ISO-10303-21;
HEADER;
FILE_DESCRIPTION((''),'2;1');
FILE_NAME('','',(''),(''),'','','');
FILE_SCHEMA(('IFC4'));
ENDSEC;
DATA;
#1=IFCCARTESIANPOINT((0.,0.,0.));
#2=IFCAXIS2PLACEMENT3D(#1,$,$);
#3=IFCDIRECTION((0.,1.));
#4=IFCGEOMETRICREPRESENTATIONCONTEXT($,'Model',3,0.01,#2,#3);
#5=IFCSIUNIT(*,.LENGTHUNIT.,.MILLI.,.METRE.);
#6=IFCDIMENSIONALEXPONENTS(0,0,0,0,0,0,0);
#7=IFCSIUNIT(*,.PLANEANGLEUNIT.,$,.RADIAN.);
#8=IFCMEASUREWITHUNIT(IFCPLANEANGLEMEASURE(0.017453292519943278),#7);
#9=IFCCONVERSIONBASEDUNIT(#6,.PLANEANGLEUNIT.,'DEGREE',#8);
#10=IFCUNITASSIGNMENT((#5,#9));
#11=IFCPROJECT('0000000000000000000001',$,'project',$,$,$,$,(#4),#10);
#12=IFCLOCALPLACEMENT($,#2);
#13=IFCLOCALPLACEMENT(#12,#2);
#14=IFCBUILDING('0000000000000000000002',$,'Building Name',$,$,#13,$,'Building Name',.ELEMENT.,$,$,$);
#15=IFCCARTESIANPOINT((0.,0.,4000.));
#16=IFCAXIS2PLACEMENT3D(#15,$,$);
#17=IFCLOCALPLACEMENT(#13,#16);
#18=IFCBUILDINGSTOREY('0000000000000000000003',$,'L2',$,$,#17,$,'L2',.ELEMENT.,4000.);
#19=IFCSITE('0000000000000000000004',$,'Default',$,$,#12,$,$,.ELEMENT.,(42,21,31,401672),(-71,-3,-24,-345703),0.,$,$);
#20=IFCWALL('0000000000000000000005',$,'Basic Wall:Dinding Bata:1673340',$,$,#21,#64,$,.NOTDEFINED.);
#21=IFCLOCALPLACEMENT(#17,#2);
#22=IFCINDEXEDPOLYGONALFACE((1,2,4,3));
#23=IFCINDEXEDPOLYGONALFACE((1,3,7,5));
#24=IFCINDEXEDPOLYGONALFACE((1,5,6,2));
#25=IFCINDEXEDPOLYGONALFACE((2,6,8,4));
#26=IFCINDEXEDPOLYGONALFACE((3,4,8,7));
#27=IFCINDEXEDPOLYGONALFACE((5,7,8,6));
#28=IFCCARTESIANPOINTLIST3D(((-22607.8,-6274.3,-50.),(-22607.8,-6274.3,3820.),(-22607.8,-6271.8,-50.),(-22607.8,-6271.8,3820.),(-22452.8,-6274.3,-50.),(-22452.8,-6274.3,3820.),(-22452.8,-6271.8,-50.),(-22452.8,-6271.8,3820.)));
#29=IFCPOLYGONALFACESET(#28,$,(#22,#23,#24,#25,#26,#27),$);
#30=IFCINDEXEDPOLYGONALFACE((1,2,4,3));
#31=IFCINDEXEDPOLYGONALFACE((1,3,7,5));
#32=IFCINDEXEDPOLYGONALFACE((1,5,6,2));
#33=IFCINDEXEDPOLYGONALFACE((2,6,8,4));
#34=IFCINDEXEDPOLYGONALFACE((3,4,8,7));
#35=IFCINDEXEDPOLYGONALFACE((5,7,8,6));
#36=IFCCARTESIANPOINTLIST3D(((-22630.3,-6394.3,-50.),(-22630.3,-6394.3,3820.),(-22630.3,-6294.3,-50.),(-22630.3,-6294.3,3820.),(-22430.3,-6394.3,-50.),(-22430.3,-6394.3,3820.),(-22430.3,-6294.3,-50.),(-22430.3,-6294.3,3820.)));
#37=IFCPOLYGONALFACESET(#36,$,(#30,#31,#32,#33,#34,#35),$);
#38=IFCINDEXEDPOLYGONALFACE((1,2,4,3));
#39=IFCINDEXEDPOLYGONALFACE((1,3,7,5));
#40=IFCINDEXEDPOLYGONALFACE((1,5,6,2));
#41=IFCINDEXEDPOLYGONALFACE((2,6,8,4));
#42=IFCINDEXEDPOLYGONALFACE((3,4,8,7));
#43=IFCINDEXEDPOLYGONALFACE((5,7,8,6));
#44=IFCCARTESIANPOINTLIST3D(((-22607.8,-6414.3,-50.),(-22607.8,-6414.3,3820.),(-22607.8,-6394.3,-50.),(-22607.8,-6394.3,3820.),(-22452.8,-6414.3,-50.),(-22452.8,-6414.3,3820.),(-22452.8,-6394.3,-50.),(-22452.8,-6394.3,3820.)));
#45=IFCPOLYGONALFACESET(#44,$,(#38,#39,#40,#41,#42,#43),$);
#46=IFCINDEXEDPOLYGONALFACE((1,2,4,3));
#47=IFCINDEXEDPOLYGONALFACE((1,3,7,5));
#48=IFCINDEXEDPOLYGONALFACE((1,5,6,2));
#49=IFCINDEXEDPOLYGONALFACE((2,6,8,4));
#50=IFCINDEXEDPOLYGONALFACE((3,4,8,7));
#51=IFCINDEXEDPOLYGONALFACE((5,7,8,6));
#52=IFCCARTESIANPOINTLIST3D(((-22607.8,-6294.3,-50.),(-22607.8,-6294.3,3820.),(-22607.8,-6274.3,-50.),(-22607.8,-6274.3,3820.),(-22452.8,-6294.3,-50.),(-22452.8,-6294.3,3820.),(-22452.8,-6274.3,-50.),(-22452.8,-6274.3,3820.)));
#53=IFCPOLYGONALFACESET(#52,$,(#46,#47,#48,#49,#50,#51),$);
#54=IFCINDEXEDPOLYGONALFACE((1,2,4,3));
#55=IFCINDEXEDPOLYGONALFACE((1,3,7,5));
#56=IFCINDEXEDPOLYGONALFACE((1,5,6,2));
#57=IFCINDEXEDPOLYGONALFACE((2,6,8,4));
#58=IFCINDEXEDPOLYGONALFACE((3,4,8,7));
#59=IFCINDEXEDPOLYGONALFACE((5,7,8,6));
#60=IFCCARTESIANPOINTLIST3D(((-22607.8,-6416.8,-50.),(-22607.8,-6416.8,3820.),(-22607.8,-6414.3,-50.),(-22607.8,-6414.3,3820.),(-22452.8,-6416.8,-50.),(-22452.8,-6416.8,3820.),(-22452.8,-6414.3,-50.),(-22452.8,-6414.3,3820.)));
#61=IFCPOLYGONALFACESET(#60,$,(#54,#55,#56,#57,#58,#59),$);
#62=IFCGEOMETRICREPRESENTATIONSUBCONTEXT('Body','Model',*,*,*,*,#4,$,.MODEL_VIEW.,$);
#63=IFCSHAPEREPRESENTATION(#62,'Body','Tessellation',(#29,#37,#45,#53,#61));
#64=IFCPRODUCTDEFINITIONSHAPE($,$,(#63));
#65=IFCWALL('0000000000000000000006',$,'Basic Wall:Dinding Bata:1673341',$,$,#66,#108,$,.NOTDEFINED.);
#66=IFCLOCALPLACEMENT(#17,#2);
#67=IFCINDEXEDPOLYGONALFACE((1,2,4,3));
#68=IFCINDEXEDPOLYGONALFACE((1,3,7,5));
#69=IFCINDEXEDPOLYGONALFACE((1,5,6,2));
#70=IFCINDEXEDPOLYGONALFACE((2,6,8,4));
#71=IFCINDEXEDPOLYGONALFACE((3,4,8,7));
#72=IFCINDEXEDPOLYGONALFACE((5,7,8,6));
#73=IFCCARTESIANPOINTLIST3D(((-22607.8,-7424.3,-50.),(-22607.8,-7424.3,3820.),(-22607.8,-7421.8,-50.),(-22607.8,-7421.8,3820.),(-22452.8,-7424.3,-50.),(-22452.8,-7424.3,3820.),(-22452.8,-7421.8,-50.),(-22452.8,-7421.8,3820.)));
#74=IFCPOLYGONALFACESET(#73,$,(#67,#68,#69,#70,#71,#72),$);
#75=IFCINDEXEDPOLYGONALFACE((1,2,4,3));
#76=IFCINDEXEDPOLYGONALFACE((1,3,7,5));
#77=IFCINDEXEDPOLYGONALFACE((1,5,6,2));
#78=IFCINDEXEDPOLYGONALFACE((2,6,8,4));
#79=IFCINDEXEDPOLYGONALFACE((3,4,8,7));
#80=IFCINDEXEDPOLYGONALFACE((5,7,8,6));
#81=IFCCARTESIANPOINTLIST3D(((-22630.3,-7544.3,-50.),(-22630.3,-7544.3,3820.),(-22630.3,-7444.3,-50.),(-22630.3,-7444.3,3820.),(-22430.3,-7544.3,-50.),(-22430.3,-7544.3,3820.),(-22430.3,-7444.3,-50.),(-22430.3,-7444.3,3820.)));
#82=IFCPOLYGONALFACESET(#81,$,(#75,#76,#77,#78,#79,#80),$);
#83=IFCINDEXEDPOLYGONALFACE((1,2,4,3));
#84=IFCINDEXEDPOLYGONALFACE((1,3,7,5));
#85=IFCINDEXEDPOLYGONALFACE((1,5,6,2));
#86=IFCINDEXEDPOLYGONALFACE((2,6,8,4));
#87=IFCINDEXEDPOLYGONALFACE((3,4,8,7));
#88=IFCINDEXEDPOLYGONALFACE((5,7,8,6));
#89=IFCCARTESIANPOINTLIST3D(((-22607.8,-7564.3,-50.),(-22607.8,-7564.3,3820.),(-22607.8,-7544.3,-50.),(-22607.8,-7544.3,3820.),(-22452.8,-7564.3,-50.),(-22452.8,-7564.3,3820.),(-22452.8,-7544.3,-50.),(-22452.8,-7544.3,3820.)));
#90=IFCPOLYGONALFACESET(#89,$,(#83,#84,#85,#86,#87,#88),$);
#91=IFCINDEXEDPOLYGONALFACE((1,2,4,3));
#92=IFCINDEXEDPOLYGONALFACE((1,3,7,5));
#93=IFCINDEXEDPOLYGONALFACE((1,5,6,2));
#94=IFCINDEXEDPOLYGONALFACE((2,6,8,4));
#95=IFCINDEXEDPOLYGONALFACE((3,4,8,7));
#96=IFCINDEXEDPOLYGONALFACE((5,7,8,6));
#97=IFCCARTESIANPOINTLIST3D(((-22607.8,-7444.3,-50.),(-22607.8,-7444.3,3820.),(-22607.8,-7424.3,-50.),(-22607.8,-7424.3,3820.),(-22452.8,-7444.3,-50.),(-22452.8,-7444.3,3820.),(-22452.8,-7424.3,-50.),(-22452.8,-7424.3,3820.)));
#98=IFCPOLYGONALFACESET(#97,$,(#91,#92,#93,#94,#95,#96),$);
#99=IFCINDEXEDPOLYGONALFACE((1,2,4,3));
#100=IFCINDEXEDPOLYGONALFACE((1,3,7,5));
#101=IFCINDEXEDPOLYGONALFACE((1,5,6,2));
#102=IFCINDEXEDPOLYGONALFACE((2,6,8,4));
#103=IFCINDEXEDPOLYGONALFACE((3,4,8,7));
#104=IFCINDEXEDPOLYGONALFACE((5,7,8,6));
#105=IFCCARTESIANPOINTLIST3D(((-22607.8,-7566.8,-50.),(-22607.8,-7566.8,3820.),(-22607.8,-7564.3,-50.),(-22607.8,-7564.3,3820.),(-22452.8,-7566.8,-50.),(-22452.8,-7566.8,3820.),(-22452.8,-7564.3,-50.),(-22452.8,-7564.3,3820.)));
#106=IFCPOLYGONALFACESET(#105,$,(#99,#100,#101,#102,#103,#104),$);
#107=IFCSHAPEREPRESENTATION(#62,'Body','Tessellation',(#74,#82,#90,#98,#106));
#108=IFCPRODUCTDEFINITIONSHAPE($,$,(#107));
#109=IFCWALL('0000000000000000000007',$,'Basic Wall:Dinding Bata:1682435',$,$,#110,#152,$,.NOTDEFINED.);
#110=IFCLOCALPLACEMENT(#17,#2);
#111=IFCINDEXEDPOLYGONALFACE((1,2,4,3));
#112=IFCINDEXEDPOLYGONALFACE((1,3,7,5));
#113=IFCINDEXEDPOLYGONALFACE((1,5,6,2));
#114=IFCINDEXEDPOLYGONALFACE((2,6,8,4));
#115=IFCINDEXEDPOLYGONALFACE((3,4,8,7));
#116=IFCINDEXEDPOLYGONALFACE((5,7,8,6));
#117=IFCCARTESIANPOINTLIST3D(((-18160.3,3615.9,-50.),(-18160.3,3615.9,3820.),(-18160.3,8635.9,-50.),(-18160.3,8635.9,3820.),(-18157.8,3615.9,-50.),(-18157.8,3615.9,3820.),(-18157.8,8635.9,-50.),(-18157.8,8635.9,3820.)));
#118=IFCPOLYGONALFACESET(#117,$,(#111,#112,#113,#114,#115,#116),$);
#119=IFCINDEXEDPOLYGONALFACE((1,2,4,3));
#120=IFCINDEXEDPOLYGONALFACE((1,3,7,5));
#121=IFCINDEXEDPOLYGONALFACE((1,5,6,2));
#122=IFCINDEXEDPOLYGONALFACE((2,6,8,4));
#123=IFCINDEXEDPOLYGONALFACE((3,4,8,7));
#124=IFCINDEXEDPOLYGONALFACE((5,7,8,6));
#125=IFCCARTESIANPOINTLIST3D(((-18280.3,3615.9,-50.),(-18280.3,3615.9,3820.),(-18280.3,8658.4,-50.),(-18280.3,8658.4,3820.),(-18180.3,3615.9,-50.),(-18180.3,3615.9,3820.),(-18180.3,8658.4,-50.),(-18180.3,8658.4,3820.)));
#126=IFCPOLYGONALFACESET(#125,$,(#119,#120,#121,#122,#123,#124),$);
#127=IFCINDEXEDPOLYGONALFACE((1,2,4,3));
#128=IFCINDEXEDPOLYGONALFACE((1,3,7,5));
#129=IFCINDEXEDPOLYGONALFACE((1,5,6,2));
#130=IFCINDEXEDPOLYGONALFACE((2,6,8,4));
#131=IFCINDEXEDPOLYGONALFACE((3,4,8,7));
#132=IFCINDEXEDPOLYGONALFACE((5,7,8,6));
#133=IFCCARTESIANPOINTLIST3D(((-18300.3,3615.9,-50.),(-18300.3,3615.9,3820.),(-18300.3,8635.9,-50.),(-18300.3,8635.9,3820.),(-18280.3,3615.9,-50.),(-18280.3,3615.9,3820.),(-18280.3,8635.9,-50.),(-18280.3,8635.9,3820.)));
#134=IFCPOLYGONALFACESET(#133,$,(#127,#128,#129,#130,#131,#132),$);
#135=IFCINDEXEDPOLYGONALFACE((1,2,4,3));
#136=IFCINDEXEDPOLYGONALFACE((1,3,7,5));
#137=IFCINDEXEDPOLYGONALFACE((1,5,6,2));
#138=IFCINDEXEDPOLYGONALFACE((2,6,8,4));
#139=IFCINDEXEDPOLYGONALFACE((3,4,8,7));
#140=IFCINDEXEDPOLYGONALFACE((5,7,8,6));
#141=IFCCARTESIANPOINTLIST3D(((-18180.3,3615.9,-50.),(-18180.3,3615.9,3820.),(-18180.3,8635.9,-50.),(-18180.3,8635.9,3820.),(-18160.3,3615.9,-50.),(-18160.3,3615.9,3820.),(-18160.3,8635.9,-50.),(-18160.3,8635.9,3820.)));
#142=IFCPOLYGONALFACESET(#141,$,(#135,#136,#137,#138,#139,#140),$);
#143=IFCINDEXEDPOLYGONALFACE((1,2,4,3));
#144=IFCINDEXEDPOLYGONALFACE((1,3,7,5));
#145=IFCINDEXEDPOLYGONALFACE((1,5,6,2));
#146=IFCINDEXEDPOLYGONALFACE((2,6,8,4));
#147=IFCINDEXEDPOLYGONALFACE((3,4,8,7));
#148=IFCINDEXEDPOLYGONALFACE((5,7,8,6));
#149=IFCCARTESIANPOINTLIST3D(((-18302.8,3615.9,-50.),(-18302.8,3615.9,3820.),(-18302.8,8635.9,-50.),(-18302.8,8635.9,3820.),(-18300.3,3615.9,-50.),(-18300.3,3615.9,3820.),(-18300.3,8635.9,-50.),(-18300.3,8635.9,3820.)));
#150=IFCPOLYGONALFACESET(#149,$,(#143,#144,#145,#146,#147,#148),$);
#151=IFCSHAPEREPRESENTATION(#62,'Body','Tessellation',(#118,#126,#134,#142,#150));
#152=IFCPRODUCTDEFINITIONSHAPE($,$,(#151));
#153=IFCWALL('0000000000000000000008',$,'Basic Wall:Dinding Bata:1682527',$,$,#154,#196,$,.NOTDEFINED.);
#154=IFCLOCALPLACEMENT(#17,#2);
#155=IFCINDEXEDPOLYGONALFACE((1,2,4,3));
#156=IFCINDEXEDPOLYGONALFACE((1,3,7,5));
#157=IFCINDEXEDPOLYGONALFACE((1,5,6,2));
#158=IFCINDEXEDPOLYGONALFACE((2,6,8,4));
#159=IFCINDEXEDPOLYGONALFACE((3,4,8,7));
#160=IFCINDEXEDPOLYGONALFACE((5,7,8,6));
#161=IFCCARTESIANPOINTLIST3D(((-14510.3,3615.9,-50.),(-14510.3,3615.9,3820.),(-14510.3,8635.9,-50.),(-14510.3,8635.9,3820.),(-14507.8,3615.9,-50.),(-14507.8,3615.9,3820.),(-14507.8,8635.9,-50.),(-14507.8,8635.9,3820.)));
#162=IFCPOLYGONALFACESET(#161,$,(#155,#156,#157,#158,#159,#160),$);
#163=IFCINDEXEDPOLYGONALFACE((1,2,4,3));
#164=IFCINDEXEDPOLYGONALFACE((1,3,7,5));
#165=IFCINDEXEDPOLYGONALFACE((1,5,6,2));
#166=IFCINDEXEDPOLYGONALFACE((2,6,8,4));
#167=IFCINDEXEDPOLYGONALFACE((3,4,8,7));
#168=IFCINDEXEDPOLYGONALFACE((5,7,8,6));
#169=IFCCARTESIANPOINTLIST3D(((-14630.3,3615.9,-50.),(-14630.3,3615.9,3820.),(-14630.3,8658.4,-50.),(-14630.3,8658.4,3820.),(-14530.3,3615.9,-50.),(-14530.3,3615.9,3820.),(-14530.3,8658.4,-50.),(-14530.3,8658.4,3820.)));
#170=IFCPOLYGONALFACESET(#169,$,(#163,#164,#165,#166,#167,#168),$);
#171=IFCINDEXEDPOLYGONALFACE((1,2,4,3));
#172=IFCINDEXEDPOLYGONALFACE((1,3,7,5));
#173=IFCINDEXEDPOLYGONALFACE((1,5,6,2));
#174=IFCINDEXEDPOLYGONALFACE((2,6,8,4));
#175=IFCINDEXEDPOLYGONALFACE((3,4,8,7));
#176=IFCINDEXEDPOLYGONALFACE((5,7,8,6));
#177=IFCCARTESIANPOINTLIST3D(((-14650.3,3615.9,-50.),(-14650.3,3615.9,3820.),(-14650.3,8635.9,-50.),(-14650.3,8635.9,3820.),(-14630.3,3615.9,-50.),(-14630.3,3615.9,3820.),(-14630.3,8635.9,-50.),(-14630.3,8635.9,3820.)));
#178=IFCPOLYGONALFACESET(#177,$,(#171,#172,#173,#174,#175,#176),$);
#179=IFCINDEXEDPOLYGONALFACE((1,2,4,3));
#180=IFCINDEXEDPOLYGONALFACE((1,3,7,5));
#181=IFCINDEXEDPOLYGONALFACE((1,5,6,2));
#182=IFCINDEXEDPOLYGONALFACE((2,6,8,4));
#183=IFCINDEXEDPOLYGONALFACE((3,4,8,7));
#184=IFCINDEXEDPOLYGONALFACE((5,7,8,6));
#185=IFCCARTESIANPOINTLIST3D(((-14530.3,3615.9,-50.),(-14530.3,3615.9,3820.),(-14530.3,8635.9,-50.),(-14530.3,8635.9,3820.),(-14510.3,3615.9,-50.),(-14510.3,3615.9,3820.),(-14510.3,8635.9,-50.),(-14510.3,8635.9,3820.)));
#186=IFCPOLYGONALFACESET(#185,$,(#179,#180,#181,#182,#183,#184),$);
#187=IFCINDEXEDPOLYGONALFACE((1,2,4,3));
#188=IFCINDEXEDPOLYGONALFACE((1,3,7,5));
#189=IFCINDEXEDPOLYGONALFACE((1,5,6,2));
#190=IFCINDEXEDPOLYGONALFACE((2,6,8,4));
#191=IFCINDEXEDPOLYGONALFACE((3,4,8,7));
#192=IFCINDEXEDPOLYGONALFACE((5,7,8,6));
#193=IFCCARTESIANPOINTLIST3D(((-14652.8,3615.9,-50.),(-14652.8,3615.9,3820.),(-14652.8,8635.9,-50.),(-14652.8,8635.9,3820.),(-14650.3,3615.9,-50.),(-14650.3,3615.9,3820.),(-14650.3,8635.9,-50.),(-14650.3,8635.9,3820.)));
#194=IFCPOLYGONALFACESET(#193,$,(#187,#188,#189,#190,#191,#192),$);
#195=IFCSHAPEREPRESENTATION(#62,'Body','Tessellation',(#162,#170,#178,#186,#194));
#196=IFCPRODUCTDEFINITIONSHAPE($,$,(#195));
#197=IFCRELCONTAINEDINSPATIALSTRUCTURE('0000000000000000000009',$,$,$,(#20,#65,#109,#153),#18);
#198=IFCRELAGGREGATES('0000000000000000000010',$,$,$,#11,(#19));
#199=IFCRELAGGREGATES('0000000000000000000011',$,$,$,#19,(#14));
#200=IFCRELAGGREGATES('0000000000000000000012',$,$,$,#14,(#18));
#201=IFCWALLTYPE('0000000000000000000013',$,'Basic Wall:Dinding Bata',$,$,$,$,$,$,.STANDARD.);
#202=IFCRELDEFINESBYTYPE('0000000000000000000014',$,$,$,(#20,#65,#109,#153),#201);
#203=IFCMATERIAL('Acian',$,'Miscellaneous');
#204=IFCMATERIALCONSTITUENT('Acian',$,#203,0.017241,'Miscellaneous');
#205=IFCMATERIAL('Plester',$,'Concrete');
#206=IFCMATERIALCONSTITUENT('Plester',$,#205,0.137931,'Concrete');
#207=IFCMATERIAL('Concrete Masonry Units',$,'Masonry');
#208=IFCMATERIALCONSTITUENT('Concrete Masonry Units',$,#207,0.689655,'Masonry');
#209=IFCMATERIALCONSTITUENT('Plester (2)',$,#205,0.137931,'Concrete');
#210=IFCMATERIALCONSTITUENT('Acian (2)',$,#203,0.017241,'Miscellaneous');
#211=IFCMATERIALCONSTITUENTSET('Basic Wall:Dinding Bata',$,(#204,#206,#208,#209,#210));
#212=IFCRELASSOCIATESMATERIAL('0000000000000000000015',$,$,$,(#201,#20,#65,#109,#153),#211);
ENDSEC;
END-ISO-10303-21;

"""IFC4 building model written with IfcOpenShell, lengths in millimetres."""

from ifc_helpers import new_model, entity, si_unit, converted_unit, direction, frame, origin, place, context, subcontext, project, spatial, indexed_curve, outline, extrude, material, constituent, constituent_set, type_object, element, save


model = new_model("IFC4")

# Units and contexts
model_context = context("Model", 3, precision=0.01, world=origin(), true_north=direction((0.0, 1.0)))
body_context = subcontext(model_context, "Body", "Model", "MODEL_VIEW")
ifc_project = project(units=[si_unit("LENGTHUNIT", "METRE", prefix="MILLI"), converted_unit("PLANEANGLEUNIT", "DEGREE", entity("IfcPlaneAngleMeasure", 0.017453292519943278), si_unit("PLANEANGLEUNIT", "RADIAN"), dimensions=[0, 0, 0, 0, 0, 0, 0])], contexts=[model_context])

# Site, building, storey
site_placement = place(None, origin())
site = spatial("IfcSite", under=ifc_project, at=site_placement, Name="Default", CompositionType="ELEMENT", RefLatitude=(42, 21, 31, 401672), RefLongitude=(-71, -3, -24, -345703), RefElevation=0.0)
building_placement = place(site_placement, origin())
building = spatial("IfcBuilding", under=site, at=building_placement, Name="Building Name", LongName="Building Name", CompositionType="ELEMENT")
storey_placement = place(building_placement, frame((0.0, 0.0, 4000.0)))
storey = spatial("IfcBuildingStorey", under=building, at=storey_placement, Name="L2", LongName="L2", CompositionType="ELEMENT", Elevation=4000.0)

# Walls
ifc_material_1 = material(Name="Acian", Category="Miscellaneous")
ifc_constituent_1 = constituent(ifc_material_1, Name="Acian", Category="Miscellaneous", fraction=0.017241)
ifc_material_2 = material(Name="Plester", Category="Concrete")
ifc_constituent_2 = constituent(ifc_material_2, Name="Plester", Category="Concrete", fraction=0.137931)
ifc_material_3 = material(Name="Concrete Masonry Units", Category="Masonry")
ifc_constituent_3 = constituent(ifc_material_3, Name="Concrete Masonry Units", Category="Masonry", fraction=0.689655)
ifc_constituent_4 = constituent(ifc_material_2, Name="Plester (2)", Category="Concrete", fraction=0.137931)
ifc_constituent_5 = constituent(ifc_material_1, Name="Acian (2)", Category="Miscellaneous", fraction=0.017241)
ifc_constituent_set = constituent_set(constituents=[ifc_constituent_1, ifc_constituent_2, ifc_constituent_3, ifc_constituent_4, ifc_constituent_5], Name="Basic Wall:Dinding Bata")
wall_type = type_object("IfcWallType", Name="Basic Wall:Dinding Bata", PredefinedType="STANDARD", material=ifc_constituent_set)
wall_1_placement = place(storey_placement, frame((-22607.8, -6344.3, -50.0)))
element("IfcWall", 1, at=wall_1_placement, inside=storey, type_object=wall_type, material=ifc_constituent_set, Name="Basic Wall:Dinding Bata:1673340", PredefinedType="NOTDEFINED", context=body_context, shape_type="SweptSolid", body=[
    extrude(outline(indexed_curve([(-1.2, -77.5), (1.2, -77.5), (1.2, 77.5), (-1.2, 77.5), (-1.2, -77.5)], self_intersect=False)), frame((77.5, 71.3, 0.0), z_axis=(0.0, 0.0, 1.0), x_axis=(0.0, -1.0, 0.0)), (0.0, 0.0, 1.0), 3870.0),
    extrude(outline(indexed_curve([(-100.0, -50.0), (100.0, -50.0), (100.0, 50.0), (-100.0, 50.0), (-100.0, -50.0)], self_intersect=False)), frame((77.5, 0.0, 0.0)), (0.0, 0.0, 1.0), 3870.0),
    extrude(outline(indexed_curve([(-77.5, -10.0), (77.5, -10.0), (77.5, 10.0), (-77.5, 10.0), (-77.5, -10.0)], self_intersect=False)), frame((77.5, -60.0, 0.0)), (0.0, 0.0, 1.0), 3870.0),
    extrude(outline(indexed_curve([(-77.5, -10.0), (77.5, -10.0), (77.5, 10.0), (-77.5, 10.0), (-77.5, -10.0)], self_intersect=False)), frame((77.5, 60.0, 0.0)), (0.0, 0.0, 1.0), 3870.0),
    extrude(outline(indexed_curve([(-1.2, -77.5), (1.2, -77.5), (1.2, 77.5), (-1.2, 77.5), (-1.2, -77.5)], self_intersect=False)), frame((77.5, -71.3, 0.0), z_axis=(0.0, 0.0, 1.0), x_axis=(0.0, 1.0, 0.0)), (0.0, 0.0, 1.0), 3870.0),
])
wall_2_placement = place(storey_placement, frame((-22607.8, -7494.3, -50.0)))
element("IfcWall", 2, at=wall_2_placement, inside=storey, type_object=wall_type, material=ifc_constituent_set, Name="Basic Wall:Dinding Bata:1673341", PredefinedType="NOTDEFINED", context=body_context, shape_type="SweptSolid", body=[
    extrude(outline(indexed_curve([(-1.3, -77.5), (1.2, -77.5), (1.2, 77.5), (-1.2, 77.5), (-1.3, -77.5)], self_intersect=False)), frame((77.5, 71.2, 0.0), z_axis=(0.0, 0.0, 1.0), x_axis=(0.0, -1.0, 0.0)), (0.0, 0.0, 1.0), 3870.0),
    extrude(outline(indexed_curve([(-100.0, -50.0), (100.0, -50.0), (100.0, 50.0), (-100.0, 50.0), (-100.0, -50.0)], self_intersect=False)), frame((77.5, 0.0, 0.0)), (0.0, 0.0, 1.0), 3870.0),
    extrude(outline(indexed_curve([(-77.5, -10.0), (77.5, -10.0), (77.5, 10.0), (-77.5, 10.0), (-77.5, -10.0)], self_intersect=False)), frame((77.5, -60.0, 0.0)), (0.0, 0.0, 1.0), 3870.0),
    extrude(outline(indexed_curve([(-77.5, -10.0), (77.5, -10.0), (77.5, 10.0), (-77.5, 10.0), (-77.5, -10.0)], self_intersect=False)), frame((77.5, 60.0, 0.0)), (0.0, 0.0, 1.0), 3870.0),
    extrude(outline(indexed_curve([(-1.2, -77.5), (1.2, -77.5), (1.3, 77.5), (-1.2, 77.5), (-1.2, -77.5)], self_intersect=False)), frame((77.5, -71.3, 0.0), z_axis=(0.0, 0.0, 1.0), x_axis=(0.0, 1.0, 0.0)), (0.0, 0.0, 1.0), 3870.0),
])
wall_3_placement = place(storey_placement, frame((-18230.3, 8635.9, -50.0), z_axis=(0.0, 0.0, 1.0), x_axis=(0.0, -1.0, 0.0)))
element("IfcWall", 3, at=wall_3_placement, inside=storey, type_object=wall_type, material=ifc_constituent_set, Name="Basic Wall:Dinding Bata:1682435", PredefinedType="NOTDEFINED", context=body_context, shape_type="SweptSolid", body=[
    extrude(outline(indexed_curve([(-1.3, -2510.0), (1.2, -2510.0), (1.3, 2510.0), (-1.2, 2510.0), (-1.3, -2510.0)], self_intersect=False)), frame((2510.0, 71.3, 0.0), z_axis=(0.0, 0.0, 1.0), x_axis=(0.0, -1.0, 0.0)), (0.0, 0.0, 1.0), 3870.0),
    extrude(outline(indexed_curve([(-2521.3, -50.0), (2521.2, -50.0), (2521.2, 50.0), (-2521.2, 50.0), (-2521.3, -50.0)], self_intersect=False)), frame((2498.8, 0.0, 0.0)), (0.0, 0.0, 1.0), 3870.0),
    extrude(outline(indexed_curve([(-2510.0, -10.0), (2510.0, -10.0), (2510.0, 10.0), (-2510.0, 10.0), (-2510.0, -10.0)], self_intersect=False)), frame((2510.0, -60.0, 0.0)), (0.0, 0.0, 1.0), 3870.0),
    extrude(outline(indexed_curve([(-2510.0, -10.0), (2510.0, -10.0), (2510.0, 10.0), (-2510.0, 10.0), (-2510.0, -10.0)], self_intersect=False)), frame((2510.0, 60.0, 0.0)), (0.0, 0.0, 1.0), 3870.0),
    extrude(outline(indexed_curve([(-1.3, -2510.0), (1.2, -2510.0), (1.3, 2510.0), (-1.2, 2510.0), (-1.3, -2510.0)], self_intersect=False)), frame((2510.0, -71.2, 0.0), z_axis=(0.0, 0.0, 1.0), x_axis=(0.0, 1.0, 0.0)), (0.0, 0.0, 1.0), 3870.0),
])
wall_4_placement = place(storey_placement, frame((-14580.3, 8635.9, -50.0), z_axis=(0.0, 0.0, 1.0), x_axis=(0.0, -1.0, 0.0)))
element("IfcWall", 4, at=wall_4_placement, inside=storey, type_object=wall_type, material=ifc_constituent_set, Name="Basic Wall:Dinding Bata:1682527", PredefinedType="NOTDEFINED", context=body_context, shape_type="SweptSolid", body=[
    extrude(outline(indexed_curve([(-1.3, -2510.0), (1.2, -2510.0), (1.3, 2510.0), (-1.2, 2510.0), (-1.3, -2510.0)], self_intersect=False)), frame((2510.0, 71.3, 0.0), z_axis=(0.0, 0.0, 1.0), x_axis=(0.0, -1.0, 0.0)), (0.0, 0.0, 1.0), 3870.0),
    extrude(outline(indexed_curve([(-2521.2, -50.0), (2521.2, -50.0), (2521.2, 50.0), (-2521.2, 50.0), (-2521.2, -50.0)], self_intersect=False)), frame((2498.7, 0.0, 0.0)), (0.0, 0.0, 1.0), 3870.0),
    extrude(outline(indexed_curve([(-2510.0, -10.0), (2510.0, -10.0), (2510.0, 10.0), (-2510.0, 10.0), (-2510.0, -10.0)], self_intersect=False)), frame((2510.0, -60.0, 0.0)), (0.0, 0.0, 1.0), 3870.0),
    extrude(outline(indexed_curve([(-2510.0, -10.0), (2510.0, -10.0), (2510.0, 10.0), (-2510.0, 10.0), (-2510.0, -10.0)], self_intersect=False)), frame((2510.0, 60.0, 0.0)), (0.0, 0.0, 1.0), 3870.0),
    extrude(outline(indexed_curve([(-1.3, -2510.0), (1.2, -2510.0), (1.3, 2510.0), (-1.2, 2510.0), (-1.3, -2510.0)], self_intersect=False)), frame((2510.0, -71.2, 0.0), z_axis=(0.0, 0.0, 1.0), x_axis=(0.0, 1.0, 0.0)), (0.0, 0.0, 1.0), 3870.0),
])

save(model, "model.ifc")
